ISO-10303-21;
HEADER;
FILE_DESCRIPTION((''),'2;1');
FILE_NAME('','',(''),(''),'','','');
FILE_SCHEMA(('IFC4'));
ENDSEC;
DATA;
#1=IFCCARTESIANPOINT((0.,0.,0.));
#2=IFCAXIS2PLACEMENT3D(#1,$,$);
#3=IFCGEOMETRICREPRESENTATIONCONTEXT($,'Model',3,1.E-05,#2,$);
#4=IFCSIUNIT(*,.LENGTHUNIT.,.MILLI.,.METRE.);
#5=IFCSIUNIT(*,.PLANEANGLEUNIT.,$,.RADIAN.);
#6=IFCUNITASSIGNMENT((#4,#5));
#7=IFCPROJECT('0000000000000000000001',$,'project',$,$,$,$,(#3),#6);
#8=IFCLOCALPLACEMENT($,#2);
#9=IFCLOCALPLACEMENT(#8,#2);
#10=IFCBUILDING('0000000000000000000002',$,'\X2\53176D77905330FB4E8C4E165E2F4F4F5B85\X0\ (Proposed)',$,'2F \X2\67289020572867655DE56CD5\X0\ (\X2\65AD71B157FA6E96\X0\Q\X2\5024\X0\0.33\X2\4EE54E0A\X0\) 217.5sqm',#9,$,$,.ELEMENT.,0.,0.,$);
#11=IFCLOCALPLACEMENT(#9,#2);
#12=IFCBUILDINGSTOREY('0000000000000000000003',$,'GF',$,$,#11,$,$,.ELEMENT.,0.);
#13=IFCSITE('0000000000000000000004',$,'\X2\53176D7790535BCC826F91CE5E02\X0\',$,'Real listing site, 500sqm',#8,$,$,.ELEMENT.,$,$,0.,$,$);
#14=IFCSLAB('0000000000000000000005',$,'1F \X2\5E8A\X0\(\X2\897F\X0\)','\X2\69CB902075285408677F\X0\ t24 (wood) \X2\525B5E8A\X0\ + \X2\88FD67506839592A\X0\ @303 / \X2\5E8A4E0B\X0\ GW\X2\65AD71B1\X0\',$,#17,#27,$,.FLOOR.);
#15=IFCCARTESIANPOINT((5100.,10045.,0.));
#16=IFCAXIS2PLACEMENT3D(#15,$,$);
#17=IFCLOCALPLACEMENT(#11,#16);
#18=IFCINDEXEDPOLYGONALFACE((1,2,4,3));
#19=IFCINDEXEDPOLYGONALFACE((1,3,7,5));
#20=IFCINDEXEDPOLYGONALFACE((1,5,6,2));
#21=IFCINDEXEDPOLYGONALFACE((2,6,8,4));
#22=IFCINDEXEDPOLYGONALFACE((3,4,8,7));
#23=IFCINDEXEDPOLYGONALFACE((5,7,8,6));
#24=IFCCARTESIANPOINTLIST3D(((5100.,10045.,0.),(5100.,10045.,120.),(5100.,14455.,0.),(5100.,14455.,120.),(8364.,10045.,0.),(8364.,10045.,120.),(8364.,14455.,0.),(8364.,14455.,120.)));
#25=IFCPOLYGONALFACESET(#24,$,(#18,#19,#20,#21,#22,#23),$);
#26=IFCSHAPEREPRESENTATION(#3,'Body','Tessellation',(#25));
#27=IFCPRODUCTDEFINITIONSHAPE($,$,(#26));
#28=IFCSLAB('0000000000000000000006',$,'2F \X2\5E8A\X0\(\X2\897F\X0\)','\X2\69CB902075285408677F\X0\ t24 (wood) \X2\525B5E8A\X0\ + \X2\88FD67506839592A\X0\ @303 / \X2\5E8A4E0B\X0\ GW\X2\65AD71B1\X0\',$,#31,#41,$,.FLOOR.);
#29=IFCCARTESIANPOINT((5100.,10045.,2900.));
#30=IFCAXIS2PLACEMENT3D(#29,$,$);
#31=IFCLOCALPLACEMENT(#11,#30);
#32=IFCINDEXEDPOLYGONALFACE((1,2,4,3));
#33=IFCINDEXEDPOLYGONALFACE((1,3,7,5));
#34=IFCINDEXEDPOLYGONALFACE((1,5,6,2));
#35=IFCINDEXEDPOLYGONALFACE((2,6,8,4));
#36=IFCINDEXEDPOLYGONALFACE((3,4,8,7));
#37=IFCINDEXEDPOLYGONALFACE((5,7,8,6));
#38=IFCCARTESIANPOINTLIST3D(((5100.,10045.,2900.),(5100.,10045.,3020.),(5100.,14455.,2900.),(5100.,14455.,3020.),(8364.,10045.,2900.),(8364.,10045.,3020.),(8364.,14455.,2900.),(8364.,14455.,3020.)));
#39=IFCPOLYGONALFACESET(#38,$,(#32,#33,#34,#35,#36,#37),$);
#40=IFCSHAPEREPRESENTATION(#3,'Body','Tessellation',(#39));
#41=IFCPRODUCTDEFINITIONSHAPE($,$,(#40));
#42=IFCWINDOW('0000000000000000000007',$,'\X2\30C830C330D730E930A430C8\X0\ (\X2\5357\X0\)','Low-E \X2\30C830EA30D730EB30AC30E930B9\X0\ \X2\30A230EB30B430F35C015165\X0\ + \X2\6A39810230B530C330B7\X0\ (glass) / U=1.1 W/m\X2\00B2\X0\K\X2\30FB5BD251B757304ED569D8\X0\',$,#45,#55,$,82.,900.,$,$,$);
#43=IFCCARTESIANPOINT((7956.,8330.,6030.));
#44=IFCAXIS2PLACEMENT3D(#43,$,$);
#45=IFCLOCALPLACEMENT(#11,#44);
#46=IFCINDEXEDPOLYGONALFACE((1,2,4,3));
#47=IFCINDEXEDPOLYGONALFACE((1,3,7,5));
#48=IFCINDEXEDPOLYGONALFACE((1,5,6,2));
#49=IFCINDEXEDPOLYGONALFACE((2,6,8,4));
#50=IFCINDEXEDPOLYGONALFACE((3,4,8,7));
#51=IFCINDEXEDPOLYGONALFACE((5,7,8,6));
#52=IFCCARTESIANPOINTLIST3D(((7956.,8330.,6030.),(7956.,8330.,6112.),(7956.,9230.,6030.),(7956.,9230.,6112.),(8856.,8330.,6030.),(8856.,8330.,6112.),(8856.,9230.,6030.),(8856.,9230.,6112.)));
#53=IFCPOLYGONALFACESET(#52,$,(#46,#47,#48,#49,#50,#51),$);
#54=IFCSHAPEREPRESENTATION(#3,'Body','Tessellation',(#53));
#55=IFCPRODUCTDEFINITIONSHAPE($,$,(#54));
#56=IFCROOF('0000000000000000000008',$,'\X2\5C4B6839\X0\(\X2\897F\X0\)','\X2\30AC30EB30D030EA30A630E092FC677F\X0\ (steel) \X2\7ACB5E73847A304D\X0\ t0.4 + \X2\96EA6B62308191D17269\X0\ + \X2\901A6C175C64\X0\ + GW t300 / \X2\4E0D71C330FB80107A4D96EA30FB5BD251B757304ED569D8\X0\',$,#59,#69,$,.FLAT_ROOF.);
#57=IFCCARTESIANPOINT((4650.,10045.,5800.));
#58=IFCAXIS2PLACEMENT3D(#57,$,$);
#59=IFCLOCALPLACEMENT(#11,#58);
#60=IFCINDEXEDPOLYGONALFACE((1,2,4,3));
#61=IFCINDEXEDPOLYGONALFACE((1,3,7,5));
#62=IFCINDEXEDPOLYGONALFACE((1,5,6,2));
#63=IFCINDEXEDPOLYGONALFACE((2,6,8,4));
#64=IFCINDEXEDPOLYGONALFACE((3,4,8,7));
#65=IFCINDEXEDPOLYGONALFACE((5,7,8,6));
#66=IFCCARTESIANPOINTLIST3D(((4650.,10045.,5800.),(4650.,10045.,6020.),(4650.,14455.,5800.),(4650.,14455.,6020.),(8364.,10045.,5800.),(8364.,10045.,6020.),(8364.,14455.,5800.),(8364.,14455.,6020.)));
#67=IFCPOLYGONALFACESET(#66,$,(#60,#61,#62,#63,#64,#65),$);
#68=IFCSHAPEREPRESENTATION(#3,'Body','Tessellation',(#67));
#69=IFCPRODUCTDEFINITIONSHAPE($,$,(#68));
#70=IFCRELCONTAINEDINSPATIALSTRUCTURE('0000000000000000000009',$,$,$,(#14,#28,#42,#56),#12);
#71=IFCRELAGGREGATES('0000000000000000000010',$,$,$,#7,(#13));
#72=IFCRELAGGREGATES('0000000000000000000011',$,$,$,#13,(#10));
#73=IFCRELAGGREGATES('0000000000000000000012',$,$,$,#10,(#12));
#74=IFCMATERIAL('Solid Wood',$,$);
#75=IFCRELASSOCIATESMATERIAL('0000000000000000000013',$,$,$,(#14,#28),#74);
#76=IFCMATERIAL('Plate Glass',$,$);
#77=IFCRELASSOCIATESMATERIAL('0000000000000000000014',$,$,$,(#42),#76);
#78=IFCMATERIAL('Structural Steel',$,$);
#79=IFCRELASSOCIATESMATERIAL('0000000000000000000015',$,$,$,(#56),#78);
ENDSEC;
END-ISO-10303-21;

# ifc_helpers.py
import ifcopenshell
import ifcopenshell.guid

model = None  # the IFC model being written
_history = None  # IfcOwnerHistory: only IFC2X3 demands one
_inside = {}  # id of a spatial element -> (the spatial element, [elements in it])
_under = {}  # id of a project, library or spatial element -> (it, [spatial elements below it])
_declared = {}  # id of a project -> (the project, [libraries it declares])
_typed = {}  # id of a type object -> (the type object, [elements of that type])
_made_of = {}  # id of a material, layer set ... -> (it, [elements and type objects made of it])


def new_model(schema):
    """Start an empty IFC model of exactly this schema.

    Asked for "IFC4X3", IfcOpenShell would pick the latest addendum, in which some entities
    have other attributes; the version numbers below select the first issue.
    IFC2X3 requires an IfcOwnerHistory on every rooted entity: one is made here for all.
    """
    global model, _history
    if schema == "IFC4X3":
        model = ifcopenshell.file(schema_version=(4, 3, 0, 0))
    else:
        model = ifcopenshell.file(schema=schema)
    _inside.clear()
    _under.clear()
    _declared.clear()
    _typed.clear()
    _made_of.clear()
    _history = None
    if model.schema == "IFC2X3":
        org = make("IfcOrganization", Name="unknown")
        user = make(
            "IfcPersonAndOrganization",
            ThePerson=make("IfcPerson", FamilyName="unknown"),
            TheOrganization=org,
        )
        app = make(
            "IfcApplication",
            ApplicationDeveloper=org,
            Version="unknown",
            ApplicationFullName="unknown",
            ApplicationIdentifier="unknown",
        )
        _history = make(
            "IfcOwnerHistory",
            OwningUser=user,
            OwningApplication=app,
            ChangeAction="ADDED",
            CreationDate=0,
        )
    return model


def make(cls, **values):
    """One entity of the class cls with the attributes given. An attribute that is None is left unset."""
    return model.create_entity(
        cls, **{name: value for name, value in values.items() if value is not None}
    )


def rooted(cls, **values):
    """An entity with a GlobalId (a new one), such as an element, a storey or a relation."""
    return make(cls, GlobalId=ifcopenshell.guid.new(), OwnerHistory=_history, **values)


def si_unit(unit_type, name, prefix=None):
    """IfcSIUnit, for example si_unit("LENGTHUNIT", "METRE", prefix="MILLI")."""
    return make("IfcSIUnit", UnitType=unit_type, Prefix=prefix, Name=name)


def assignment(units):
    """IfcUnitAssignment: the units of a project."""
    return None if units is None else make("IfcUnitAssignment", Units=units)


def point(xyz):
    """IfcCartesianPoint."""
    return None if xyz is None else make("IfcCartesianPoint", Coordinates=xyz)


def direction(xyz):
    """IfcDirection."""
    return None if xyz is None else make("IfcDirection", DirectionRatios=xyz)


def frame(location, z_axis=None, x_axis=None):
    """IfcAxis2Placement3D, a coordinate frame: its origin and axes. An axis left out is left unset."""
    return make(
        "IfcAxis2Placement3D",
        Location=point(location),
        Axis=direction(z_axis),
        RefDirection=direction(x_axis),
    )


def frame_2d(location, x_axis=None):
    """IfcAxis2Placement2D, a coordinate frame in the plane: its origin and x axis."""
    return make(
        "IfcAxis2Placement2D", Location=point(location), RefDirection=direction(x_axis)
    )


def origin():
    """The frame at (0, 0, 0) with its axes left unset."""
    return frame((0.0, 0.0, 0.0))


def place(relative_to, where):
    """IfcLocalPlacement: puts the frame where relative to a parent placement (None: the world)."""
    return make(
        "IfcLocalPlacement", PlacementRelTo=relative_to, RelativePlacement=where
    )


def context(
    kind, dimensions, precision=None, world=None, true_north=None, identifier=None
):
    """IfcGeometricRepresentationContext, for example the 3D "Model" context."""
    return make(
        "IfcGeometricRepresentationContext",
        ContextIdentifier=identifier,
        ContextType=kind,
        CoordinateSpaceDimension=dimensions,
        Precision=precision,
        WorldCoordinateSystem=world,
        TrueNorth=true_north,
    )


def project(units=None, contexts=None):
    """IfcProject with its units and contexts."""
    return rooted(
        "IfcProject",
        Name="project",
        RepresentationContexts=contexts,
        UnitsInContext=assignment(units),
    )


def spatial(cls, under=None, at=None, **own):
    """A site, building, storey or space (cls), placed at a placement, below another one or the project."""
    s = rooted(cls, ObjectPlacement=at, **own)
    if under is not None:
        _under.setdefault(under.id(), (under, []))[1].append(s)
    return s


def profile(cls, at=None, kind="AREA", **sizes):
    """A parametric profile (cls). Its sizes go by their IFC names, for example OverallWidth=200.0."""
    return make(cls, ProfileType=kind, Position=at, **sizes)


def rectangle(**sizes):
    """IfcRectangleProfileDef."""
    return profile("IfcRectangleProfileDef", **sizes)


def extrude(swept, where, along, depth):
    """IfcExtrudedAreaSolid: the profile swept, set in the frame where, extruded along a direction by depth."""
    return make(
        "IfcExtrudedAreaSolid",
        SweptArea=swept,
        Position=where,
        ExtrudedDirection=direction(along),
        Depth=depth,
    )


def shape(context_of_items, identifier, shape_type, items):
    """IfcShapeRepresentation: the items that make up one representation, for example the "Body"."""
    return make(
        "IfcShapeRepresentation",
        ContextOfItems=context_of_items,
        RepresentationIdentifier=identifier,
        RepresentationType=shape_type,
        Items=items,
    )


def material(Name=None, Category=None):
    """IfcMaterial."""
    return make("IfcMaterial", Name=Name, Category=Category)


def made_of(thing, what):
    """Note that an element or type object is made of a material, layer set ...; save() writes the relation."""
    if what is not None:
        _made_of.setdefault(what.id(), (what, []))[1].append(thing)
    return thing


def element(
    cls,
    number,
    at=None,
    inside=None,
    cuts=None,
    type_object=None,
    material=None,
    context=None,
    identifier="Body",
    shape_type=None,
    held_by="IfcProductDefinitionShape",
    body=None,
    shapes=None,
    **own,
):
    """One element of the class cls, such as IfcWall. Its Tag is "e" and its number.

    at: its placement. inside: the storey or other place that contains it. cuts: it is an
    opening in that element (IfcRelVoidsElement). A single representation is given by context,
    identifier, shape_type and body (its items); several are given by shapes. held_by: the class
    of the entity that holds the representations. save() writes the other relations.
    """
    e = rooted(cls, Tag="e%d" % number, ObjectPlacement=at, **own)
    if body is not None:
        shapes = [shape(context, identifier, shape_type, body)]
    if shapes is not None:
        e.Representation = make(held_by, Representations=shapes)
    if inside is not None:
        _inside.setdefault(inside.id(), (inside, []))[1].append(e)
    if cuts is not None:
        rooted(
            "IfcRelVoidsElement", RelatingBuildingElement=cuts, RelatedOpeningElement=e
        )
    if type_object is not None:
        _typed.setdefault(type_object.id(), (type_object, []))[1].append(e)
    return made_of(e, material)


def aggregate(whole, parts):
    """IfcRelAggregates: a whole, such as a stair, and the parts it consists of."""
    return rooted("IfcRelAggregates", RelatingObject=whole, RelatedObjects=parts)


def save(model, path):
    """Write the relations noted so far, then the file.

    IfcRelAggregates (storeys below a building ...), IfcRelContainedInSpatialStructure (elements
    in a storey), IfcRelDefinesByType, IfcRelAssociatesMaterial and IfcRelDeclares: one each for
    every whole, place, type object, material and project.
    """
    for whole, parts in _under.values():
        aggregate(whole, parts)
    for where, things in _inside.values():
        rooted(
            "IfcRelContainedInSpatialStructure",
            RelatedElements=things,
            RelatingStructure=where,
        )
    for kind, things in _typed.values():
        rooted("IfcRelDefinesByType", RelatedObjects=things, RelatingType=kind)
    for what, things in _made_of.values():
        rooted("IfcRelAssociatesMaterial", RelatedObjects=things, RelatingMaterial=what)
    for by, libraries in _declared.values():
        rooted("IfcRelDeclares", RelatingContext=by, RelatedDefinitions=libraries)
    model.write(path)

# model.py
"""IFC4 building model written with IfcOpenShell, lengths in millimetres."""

from ifc_helpers import new_model, si_unit, frame, frame_2d, origin, place, context, project, spatial, rectangle, extrude, material, element, save


model = new_model("IFC4")

# Units and contexts
model_context = context("Model", 3, precision=1e-05, world=origin())
ifc_project = project(units=[si_unit("LENGTHUNIT", "METRE", prefix="MILLI"), si_unit("PLANEANGLEUNIT", "RADIAN")], contexts=[model_context])

# Site, building, storey
site_placement = place(None, origin())
site = spatial("IfcSite", under=ifc_project, at=site_placement, Name="北海道富良野市", ObjectType="Real listing site, 500sqm", CompositionType="ELEMENT", RefElevation=0.0)
building_placement = place(site_placement, origin())
building = spatial("IfcBuilding", under=site, at=building_placement, Name="北海道・二世帯住宅 (Proposed)", ObjectType="2F 木造在来工法 (断熱基準Q値0.33以上) 217.5sqm", CompositionType="ELEMENT", ElevationOfRefHeight=0.0, ElevationOfTerrain=0.0)
storey_placement = place(building_placement, origin())
storey = spatial("IfcBuildingStorey", under=building, at=storey_placement, Name="GF", CompositionType="ELEMENT", Elevation=0.0)

# Shared definitions
ifc_material_1 = material(Name="Solid Wood")

# Slabs
slab_1_placement = place(storey_placement, frame((5100.0, 10045.0, 0.0)))
element("IfcSlab", 1, at=slab_1_placement, inside=storey, material=ifc_material_1, Name="1F 床(西)", Description="構造用合板 t24 (wood) 剛床 + 製材根太 @303 / 床下 GW断熱", PredefinedType="FLOOR", context=model_context, shape_type="SweptSolid", body=[
    extrude(rectangle(XDim=3264.0, YDim=4410.0, at=frame_2d((1632.0, 2205.0))), frame((5100.0, 10045.0, 0.0)), (0.0, 0.0, 1.0), 120.0),
])
slab_2_placement = place(storey_placement, frame((5100.0, 10045.0, 2900.0)))
element("IfcSlab", 2, at=slab_2_placement, inside=storey, material=ifc_material_1, Name="2F 床(西)", Description="構造用合板 t24 (wood) 剛床 + 製材根太 @303 / 床下 GW断熱", PredefinedType="FLOOR", context=model_context, shape_type="SweptSolid", body=[
    extrude(rectangle(XDim=3264.0, YDim=4410.0, at=frame_2d((1632.0, 2205.0))), frame((5100.0, 10045.0, 2900.0)), (0.0, 0.0, 1.0), 120.0),
])

# Window
ifc_material_2 = material(Name="Plate Glass")
window_placement = place(storey_placement, frame((7956.0, 8330.0, 6030.0)))
element("IfcWindow", 3, at=window_placement, inside=storey, material=ifc_material_2, Name="トップライト (南)", Description="Low-E トリプルガラス アルゴン封入 + 樹脂サッシ (glass) / U=1.1 W/m²K・寒冷地仕様", OverallHeight=82.0, OverallWidth=900.0, context=model_context, shape_type="SweptSolid", body=[
    extrude(rectangle(XDim=900.0, YDim=900.0, at=frame_2d((450.0, 450.0))), frame((7956.0, 8330.0, 6030.0)), (0.0, 0.0, 1.0), 82.0),
])

# Roof
ifc_material_3 = material(Name="Structural Steel")
for number, where, name in (
    (4, (4650.0, 10045.0, 5800.0), "屋根(西)"),
):
    element("IfcRoof", number, at=place(storey_placement, frame(where)), inside=storey, material=ifc_material_3, Name=name, Description="ガルバリウム鋼板 (steel) 立平葺き t0.4 + 雪止め金物 + 通気層 + GW t300 / 不燃・耐積雪・寒冷地仕様", PredefinedType="FLAT_ROOF", context=model_context, shape_type="SweptSolid", body=[
        extrude(rectangle(XDim=3714.0, YDim=4410.0, at=frame_2d((1857.0, 2205.0))), frame((4650.0, 10045.0, 5800.0)), (0.0, 0.0, 1.0), 220.0),
    ])

save(model, "model.ifc")
